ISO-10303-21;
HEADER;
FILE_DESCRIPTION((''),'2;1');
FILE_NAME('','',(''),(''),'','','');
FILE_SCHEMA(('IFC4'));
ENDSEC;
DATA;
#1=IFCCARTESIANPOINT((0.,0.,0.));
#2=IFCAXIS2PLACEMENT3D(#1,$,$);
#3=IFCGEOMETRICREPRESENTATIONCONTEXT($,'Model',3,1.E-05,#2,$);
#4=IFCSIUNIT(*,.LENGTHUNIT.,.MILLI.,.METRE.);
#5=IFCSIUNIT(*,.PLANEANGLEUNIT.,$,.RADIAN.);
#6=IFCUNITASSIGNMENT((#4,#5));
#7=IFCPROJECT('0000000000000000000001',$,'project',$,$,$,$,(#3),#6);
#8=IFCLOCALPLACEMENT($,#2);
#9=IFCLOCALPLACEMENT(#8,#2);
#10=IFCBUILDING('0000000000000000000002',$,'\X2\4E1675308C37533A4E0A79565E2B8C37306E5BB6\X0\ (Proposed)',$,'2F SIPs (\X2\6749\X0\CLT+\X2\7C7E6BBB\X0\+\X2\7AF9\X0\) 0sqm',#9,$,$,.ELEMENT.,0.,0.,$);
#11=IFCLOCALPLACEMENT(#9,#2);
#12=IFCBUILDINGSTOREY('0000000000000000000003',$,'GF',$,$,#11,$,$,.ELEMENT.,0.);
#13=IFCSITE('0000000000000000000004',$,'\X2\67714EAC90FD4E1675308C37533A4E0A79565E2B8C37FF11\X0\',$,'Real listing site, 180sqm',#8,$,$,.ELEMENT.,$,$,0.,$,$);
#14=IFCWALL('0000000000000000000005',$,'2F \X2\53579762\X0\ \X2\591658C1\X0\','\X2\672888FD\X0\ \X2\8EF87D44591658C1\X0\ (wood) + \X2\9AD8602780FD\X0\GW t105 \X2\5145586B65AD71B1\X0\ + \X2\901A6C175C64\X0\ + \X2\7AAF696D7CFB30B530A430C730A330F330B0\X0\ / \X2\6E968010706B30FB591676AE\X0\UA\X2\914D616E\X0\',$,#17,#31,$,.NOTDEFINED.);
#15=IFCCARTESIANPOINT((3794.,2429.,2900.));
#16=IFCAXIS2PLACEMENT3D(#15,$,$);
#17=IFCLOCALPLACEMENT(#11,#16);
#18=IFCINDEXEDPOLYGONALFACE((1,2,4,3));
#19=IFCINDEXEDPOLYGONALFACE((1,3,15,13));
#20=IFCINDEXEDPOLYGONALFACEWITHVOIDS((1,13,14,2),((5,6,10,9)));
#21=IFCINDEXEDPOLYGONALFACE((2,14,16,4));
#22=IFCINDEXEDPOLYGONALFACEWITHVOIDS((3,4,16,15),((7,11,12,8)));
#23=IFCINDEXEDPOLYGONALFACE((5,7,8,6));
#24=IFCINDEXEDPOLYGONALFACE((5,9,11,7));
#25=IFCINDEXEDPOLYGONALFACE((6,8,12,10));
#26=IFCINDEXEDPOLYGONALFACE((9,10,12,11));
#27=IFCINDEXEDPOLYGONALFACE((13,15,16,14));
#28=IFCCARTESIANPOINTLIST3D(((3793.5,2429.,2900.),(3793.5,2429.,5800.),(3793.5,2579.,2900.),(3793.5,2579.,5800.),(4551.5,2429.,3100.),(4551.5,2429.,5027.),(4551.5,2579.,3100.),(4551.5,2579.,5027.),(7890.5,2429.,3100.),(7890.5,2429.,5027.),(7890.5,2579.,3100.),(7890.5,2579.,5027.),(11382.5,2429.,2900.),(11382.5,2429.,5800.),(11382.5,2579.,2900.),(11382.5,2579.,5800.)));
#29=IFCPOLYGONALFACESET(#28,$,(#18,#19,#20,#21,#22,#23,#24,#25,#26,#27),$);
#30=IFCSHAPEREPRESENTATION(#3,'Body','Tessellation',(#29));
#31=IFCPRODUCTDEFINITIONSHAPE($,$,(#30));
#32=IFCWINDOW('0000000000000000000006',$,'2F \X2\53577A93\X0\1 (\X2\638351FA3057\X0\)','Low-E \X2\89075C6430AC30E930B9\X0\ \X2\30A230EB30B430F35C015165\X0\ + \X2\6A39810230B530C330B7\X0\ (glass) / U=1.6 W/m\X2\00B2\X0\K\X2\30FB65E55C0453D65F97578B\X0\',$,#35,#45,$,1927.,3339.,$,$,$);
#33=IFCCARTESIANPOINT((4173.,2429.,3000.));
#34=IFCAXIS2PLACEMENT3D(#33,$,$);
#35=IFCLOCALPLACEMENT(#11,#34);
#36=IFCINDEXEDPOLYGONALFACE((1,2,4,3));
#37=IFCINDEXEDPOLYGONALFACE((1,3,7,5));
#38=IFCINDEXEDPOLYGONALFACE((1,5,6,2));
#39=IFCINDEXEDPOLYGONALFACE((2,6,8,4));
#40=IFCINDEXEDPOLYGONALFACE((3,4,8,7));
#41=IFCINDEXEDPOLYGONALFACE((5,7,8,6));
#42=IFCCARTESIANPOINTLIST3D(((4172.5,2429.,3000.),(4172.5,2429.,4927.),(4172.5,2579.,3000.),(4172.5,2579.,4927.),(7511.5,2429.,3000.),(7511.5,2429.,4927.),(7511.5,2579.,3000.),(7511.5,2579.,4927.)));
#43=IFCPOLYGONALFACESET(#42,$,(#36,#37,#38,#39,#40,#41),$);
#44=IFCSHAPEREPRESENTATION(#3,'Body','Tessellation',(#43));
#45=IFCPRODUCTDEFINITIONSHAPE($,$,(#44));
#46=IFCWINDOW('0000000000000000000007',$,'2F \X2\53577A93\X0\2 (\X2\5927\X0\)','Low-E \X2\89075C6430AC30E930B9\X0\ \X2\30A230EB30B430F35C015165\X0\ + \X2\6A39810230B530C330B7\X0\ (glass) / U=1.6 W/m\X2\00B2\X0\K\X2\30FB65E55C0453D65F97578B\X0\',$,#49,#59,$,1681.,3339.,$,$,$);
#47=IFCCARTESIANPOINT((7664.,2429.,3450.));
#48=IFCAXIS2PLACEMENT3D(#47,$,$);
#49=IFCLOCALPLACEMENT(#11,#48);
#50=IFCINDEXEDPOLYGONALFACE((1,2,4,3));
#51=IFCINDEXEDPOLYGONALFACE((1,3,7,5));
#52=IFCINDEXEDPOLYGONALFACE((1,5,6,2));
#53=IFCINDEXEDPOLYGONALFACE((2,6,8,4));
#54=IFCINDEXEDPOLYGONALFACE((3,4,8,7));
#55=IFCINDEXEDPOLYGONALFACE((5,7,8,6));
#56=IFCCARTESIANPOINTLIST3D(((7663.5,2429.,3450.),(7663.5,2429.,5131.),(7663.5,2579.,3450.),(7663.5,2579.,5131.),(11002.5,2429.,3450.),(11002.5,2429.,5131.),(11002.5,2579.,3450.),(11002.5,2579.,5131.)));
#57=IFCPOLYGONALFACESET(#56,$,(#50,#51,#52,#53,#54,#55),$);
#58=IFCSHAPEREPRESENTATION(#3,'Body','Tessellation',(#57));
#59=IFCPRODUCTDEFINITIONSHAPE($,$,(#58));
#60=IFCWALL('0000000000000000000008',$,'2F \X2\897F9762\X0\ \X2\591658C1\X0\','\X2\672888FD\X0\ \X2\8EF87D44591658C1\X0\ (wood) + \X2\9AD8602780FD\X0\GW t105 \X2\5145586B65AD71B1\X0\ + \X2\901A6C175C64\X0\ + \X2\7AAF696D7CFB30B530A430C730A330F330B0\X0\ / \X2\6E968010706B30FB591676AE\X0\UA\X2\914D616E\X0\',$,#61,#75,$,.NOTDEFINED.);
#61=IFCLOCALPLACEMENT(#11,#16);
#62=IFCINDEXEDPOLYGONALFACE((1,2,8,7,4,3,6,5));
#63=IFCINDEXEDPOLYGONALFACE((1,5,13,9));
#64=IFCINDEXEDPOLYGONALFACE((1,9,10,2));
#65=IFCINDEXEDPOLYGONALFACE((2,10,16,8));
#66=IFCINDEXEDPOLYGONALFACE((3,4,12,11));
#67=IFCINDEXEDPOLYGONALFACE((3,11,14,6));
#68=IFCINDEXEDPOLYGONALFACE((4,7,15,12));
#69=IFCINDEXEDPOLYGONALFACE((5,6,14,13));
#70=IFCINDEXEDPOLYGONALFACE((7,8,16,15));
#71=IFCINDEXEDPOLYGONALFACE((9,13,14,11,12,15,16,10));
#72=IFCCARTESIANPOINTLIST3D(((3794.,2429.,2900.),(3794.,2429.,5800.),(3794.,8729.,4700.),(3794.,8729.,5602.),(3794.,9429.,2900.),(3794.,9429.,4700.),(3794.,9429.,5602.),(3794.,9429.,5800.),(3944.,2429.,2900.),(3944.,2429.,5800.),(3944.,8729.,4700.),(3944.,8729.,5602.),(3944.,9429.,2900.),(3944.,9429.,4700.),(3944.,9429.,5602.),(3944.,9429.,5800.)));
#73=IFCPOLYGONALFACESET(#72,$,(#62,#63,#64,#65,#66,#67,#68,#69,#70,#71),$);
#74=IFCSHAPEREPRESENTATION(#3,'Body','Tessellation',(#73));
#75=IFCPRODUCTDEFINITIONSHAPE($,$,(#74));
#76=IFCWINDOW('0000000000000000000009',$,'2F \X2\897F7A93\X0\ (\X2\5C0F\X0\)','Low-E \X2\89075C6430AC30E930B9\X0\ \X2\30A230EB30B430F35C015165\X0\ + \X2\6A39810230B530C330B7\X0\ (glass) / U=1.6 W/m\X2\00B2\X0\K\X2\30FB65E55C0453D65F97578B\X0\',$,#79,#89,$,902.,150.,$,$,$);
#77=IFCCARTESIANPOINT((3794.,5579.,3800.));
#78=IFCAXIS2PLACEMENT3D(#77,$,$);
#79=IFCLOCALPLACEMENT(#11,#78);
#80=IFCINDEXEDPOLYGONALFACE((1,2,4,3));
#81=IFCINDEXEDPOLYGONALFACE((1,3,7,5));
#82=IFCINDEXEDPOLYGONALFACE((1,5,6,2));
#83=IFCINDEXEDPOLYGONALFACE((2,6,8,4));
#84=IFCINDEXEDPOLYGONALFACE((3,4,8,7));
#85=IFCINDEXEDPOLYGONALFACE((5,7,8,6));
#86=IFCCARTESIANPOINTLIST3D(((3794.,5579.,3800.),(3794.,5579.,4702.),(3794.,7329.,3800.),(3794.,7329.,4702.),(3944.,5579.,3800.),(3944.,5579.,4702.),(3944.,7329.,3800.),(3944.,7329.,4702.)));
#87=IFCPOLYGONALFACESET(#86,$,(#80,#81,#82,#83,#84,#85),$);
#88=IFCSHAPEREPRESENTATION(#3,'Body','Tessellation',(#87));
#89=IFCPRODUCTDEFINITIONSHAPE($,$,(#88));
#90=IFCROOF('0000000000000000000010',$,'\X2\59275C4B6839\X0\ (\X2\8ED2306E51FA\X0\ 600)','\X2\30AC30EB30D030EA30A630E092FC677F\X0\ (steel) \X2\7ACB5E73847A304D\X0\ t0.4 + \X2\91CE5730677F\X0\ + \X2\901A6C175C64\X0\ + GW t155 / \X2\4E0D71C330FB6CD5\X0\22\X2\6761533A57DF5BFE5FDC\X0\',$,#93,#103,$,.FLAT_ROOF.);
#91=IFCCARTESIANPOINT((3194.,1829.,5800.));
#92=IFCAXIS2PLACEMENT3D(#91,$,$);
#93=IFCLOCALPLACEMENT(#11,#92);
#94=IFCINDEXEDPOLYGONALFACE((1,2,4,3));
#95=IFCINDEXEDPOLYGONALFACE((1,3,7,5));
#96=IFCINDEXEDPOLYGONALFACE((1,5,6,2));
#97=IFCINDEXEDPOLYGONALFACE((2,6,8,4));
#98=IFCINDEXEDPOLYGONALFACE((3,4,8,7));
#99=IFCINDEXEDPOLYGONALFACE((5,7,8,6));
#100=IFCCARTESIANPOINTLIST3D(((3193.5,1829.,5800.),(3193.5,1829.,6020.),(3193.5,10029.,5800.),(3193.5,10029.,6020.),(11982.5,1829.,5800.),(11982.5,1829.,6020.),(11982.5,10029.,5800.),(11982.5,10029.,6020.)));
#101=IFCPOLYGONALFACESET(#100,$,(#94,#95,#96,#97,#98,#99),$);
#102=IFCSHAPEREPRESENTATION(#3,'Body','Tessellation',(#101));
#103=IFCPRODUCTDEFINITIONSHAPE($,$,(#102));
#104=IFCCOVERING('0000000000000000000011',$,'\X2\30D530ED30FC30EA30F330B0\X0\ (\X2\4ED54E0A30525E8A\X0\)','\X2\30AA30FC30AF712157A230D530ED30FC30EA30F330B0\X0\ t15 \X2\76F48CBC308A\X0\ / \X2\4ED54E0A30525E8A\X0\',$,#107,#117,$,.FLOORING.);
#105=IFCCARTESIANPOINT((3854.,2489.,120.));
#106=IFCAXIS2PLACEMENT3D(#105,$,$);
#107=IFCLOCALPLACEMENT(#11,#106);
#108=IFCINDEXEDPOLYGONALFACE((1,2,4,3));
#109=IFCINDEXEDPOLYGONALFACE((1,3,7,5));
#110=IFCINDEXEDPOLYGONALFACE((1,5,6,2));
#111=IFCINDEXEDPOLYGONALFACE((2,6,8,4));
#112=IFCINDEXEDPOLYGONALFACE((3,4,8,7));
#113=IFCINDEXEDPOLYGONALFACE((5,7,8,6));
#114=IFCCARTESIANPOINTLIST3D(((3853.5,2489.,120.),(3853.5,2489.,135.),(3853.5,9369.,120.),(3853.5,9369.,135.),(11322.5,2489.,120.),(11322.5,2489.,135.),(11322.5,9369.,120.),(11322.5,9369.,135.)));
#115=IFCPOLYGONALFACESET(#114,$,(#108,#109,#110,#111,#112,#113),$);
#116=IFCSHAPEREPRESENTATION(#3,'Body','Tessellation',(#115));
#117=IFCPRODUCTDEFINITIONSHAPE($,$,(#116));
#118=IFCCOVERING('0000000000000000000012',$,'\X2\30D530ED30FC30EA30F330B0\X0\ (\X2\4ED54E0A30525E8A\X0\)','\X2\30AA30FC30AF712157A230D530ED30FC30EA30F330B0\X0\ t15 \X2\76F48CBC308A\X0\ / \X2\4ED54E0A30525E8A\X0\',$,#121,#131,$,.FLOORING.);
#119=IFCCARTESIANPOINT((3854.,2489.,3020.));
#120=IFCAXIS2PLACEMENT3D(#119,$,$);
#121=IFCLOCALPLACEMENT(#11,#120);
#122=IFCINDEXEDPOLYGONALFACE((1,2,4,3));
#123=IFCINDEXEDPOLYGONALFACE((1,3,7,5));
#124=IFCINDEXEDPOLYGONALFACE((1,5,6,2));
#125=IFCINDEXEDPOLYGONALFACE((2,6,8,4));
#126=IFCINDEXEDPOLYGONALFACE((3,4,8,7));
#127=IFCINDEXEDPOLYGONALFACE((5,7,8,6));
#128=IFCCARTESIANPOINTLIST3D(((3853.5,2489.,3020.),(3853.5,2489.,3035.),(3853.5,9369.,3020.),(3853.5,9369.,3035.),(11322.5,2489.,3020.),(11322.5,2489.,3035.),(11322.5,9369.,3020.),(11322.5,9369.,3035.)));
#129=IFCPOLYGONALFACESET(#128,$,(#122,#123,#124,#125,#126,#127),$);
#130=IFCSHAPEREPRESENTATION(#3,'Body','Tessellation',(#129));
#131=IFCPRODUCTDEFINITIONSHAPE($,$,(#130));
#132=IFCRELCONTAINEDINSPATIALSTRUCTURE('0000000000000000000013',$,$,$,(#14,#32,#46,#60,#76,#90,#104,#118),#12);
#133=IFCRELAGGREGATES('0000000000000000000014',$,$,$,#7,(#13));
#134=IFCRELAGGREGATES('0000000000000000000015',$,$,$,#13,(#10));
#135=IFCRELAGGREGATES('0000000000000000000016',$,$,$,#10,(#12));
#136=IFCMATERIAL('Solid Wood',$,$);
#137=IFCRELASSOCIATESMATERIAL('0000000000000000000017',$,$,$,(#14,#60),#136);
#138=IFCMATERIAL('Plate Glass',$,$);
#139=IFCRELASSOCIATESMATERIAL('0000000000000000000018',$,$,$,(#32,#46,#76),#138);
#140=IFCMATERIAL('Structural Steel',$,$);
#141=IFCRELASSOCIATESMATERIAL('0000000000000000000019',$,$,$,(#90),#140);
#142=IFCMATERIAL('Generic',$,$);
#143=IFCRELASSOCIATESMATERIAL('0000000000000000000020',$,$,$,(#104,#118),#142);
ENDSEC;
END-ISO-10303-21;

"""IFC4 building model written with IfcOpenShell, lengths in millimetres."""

from ifc_helpers import new_model, si_unit, frame, frame_2d, origin, place, context, project, spatial, rectangle, extrude, material, element, fill, save


model = new_model("IFC4")

# Units and contexts
model_context = context("Model", 3, precision=1e-05, world=origin())
ifc_project = project(units=[si_unit("LENGTHUNIT", "METRE", prefix="MILLI"), si_unit("PLANEANGLEUNIT", "RADIAN")], contexts=[model_context])

# Site, building, storey
site_placement = place(None, origin())
site = spatial("IfcSite", under=ifc_project, at=site_placement, Name="東京都世田谷区上祖師谷１", ObjectType="Real listing site, 180sqm", CompositionType="ELEMENT", RefElevation=0.0)
building_placement = place(site_placement, origin())
building = spatial("IfcBuilding", under=site, at=building_placement, Name="世田谷区上祖師谷の家 (Proposed)", ObjectType="2F SIPs (杉CLT+籾殻+竹) 0sqm", CompositionType="ELEMENT", ElevationOfRefHeight=0.0, ElevationOfTerrain=0.0)
storey_placement = place(building_placement, origin())
storey = spatial("IfcBuildingStorey", under=building, at=storey_placement, Name="GF", CompositionType="ELEMENT", Elevation=0.0)

# Shared definitions
ifc_material_1 = material(Name="Solid Wood")

# Shared definitions
ifc_material_2 = material(Name="Plate Glass")

# Wall, openings, windows
wall_1_placement = place(storey_placement, frame((3794.0, 2429.0, 2900.0)))
wall_1 = element("IfcWall", 1, at=wall_1_placement, inside=storey, material=ifc_material_1, Name="2F 南面 外壁", Description="木製 軸組外壁 (wood) + 高性能GW t105 充填断熱 + 通気層 + 窯業系サイディング / 準耐火・外皮UA配慮", PredefinedType="NOTDEFINED", context=model_context, shape_type="SweptSolid", body=[
    extrude(rectangle(XDim=7589.0, YDim=150.0, at=frame_2d((3794.0, 75.0))), frame((3794.0, 2429.0, 2900.0)), (0.0, 0.0, 1.0), 2900.0),
])
opening_1_placement = place(storey_placement, frame((4173.0, 2429.0, 3000.0)))
opening_1 = element("IfcOpeningElement", 2, at=opening_1_placement, cuts=wall_1, PredefinedType="NOTDEFINED", context=model_context, shape_type="SweptSolid", body=[
    extrude(rectangle(XDim=3339.0, YDim=150.0, at=frame_2d((1669.0, 75.0))), frame((4173.0, 2429.0, 3000.0)), (0.0, 0.0, 1.0), 1927.0),
])
opening_2_placement = place(storey_placement, frame((7664.0, 2429.0, 3450.0)))
opening_2 = element("IfcOpeningElement", 3, at=opening_2_placement, cuts=wall_1, PredefinedType="NOTDEFINED", context=model_context, shape_type="SweptSolid", body=[
    extrude(rectangle(XDim=3339.0, YDim=150.0, at=frame_2d((1669.0, 75.0))), frame((7664.0, 2429.0, 3450.0)), (0.0, 0.0, 1.0), 1681.0),
])
window_1_placement = place(storey_placement, frame((4173.0, 2429.0, 3000.0)))
window_1 = element("IfcWindow", 4, at=window_1_placement, inside=storey, material=ifc_material_2, Name="2F 南窓1 (掃出し)", Description="Low-E 複層ガラス アルゴン封入 + 樹脂サッシ (glass) / U=1.6 W/m²K・日射取得型", OverallHeight=1927.0, OverallWidth=3339.0, context=model_context, shape_type="SweptSolid", body=[
    extrude(rectangle(XDim=3339.0, YDim=150.0, at=frame_2d((1669.0, 75.0))), frame((4173.0, 2429.0, 3000.0)), (0.0, 0.0, 1.0), 1927.0),
])
fill(opening_1, window_1)
window_2_placement = place(storey_placement, frame((7664.0, 2429.0, 3450.0)))
window_2 = element("IfcWindow", 5, at=window_2_placement, inside=storey, material=ifc_material_2, Name="2F 南窓2 (大)", Description="Low-E 複層ガラス アルゴン封入 + 樹脂サッシ (glass) / U=1.6 W/m²K・日射取得型", OverallHeight=1681.0, OverallWidth=3339.0, context=model_context, shape_type="SweptSolid", body=[
    extrude(rectangle(XDim=3339.0, YDim=150.0, at=frame_2d((1669.0, 75.0))), frame((7664.0, 2429.0, 3450.0)), (0.0, 0.0, 1.0), 1681.0),
])
fill(opening_2, window_2)

# Wall, opening, window
wall_2_placement = place(storey_placement, frame((3794.0, 2429.0, 2900.0)))
wall_2 = element("IfcWall", 6, at=wall_2_placement, inside=storey, material=ifc_material_1, Name="2F 西面 外壁", Description="木製 軸組外壁 (wood) + 高性能GW t105 充填断熱 + 通気層 + 窯業系サイディング / 準耐火・外皮UA配慮", PredefinedType="NOTDEFINED", context=model_context, shape_type="SweptSolid", body=[
    extrude(rectangle(XDim=150.0, YDim=7000.0, at=frame_2d((75.0, 3500.0))), frame((3794.0, 2429.0, 2900.0)), (0.0, 0.0, 1.0), 2900.0),
])
opening_3_placement = place(storey_placement, frame((3794.0, 5579.0, 3800.0)))
opening_3 = element("IfcOpeningElement", 7, at=opening_3_placement, cuts=wall_2, PredefinedType="NOTDEFINED", context=model_context, shape_type="SweptSolid", body=[
    extrude(rectangle(XDim=150.0, YDim=1750.0, at=frame_2d((75.0, 875.0))), frame((3794.0, 5579.0, 3800.0)), (0.0, 0.0, 1.0), 902.0),
])
window_3_placement = place(storey_placement, frame((3794.0, 5579.0, 3800.0)))
window_3 = element("IfcWindow", 8, at=window_3_placement, inside=storey, material=ifc_material_2, Name="2F 西窓 (小)", Description="Low-E 複層ガラス アルゴン封入 + 樹脂サッシ (glass) / U=1.6 W/m²K・日射取得型", OverallHeight=902.0, OverallWidth=150.0, context=model_context, shape_type="SweptSolid", body=[
    extrude(rectangle(XDim=150.0, YDim=1750.0, at=frame_2d((75.0, 875.0))), frame((3794.0, 5579.0, 3800.0)), (0.0, 0.0, 1.0), 902.0),
])
fill(opening_3, window_3)

# Roof
ifc_material_3 = material(Name="Structural Steel")
roof_placement = place(storey_placement, frame((3194.0, 1829.0, 5800.0)))
element("IfcRoof", 9, at=roof_placement, inside=storey, material=ifc_material_3, Name="大屋根 (軒の出 600)", Description="ガルバリウム鋼板 (steel) 立平葺き t0.4 + 野地板 + 通気層 + GW t155 / 不燃・法22条区域対応", PredefinedType="FLAT_ROOF", context=model_context, shape_type="SweptSolid", body=[
    extrude(rectangle(XDim=8789.0, YDim=8200.0, at=frame_2d((4394.0, 4100.0))), frame((3194.0, 1829.0, 5800.0)), (0.0, 0.0, 1.0), 220.0),
])

# Coverings
ifc_material_4 = material(Name="Generic")
covering_1_placement = place(storey_placement, frame((3854.0, 2489.0, 120.0)))
element("IfcCovering", 10, at=covering_1_placement, inside=storey, material=ifc_material_4, Name="フローリング (仕上げ床)", Description="オーク無垢フローリング t15 直貼り / 仕上げ床", PredefinedType="FLOORING", context=model_context, shape_type="SweptSolid", body=[
    extrude(rectangle(XDim=7469.0, YDim=6880.0, at=frame_2d((3734.0, 3440.0))), frame((3854.0, 2489.0, 120.0)), (0.0, 0.0, 1.0), 15.0),
])
covering_2_placement = place(storey_placement, frame((3854.0, 2489.0, 3020.0)))
element("IfcCovering", 11, at=covering_2_placement, inside=storey, material=ifc_material_4, Name="フローリング (仕上げ床)", Description="オーク無垢フローリング t15 直貼り / 仕上げ床", PredefinedType="FLOORING", context=model_context, shape_type="SweptSolid", body=[
    extrude(rectangle(XDim=7469.0, YDim=6880.0, at=frame_2d((3734.0, 3440.0))), frame((3854.0, 2489.0, 3020.0)), (0.0, 0.0, 1.0), 15.0),
])

save(model, "model.ifc")
